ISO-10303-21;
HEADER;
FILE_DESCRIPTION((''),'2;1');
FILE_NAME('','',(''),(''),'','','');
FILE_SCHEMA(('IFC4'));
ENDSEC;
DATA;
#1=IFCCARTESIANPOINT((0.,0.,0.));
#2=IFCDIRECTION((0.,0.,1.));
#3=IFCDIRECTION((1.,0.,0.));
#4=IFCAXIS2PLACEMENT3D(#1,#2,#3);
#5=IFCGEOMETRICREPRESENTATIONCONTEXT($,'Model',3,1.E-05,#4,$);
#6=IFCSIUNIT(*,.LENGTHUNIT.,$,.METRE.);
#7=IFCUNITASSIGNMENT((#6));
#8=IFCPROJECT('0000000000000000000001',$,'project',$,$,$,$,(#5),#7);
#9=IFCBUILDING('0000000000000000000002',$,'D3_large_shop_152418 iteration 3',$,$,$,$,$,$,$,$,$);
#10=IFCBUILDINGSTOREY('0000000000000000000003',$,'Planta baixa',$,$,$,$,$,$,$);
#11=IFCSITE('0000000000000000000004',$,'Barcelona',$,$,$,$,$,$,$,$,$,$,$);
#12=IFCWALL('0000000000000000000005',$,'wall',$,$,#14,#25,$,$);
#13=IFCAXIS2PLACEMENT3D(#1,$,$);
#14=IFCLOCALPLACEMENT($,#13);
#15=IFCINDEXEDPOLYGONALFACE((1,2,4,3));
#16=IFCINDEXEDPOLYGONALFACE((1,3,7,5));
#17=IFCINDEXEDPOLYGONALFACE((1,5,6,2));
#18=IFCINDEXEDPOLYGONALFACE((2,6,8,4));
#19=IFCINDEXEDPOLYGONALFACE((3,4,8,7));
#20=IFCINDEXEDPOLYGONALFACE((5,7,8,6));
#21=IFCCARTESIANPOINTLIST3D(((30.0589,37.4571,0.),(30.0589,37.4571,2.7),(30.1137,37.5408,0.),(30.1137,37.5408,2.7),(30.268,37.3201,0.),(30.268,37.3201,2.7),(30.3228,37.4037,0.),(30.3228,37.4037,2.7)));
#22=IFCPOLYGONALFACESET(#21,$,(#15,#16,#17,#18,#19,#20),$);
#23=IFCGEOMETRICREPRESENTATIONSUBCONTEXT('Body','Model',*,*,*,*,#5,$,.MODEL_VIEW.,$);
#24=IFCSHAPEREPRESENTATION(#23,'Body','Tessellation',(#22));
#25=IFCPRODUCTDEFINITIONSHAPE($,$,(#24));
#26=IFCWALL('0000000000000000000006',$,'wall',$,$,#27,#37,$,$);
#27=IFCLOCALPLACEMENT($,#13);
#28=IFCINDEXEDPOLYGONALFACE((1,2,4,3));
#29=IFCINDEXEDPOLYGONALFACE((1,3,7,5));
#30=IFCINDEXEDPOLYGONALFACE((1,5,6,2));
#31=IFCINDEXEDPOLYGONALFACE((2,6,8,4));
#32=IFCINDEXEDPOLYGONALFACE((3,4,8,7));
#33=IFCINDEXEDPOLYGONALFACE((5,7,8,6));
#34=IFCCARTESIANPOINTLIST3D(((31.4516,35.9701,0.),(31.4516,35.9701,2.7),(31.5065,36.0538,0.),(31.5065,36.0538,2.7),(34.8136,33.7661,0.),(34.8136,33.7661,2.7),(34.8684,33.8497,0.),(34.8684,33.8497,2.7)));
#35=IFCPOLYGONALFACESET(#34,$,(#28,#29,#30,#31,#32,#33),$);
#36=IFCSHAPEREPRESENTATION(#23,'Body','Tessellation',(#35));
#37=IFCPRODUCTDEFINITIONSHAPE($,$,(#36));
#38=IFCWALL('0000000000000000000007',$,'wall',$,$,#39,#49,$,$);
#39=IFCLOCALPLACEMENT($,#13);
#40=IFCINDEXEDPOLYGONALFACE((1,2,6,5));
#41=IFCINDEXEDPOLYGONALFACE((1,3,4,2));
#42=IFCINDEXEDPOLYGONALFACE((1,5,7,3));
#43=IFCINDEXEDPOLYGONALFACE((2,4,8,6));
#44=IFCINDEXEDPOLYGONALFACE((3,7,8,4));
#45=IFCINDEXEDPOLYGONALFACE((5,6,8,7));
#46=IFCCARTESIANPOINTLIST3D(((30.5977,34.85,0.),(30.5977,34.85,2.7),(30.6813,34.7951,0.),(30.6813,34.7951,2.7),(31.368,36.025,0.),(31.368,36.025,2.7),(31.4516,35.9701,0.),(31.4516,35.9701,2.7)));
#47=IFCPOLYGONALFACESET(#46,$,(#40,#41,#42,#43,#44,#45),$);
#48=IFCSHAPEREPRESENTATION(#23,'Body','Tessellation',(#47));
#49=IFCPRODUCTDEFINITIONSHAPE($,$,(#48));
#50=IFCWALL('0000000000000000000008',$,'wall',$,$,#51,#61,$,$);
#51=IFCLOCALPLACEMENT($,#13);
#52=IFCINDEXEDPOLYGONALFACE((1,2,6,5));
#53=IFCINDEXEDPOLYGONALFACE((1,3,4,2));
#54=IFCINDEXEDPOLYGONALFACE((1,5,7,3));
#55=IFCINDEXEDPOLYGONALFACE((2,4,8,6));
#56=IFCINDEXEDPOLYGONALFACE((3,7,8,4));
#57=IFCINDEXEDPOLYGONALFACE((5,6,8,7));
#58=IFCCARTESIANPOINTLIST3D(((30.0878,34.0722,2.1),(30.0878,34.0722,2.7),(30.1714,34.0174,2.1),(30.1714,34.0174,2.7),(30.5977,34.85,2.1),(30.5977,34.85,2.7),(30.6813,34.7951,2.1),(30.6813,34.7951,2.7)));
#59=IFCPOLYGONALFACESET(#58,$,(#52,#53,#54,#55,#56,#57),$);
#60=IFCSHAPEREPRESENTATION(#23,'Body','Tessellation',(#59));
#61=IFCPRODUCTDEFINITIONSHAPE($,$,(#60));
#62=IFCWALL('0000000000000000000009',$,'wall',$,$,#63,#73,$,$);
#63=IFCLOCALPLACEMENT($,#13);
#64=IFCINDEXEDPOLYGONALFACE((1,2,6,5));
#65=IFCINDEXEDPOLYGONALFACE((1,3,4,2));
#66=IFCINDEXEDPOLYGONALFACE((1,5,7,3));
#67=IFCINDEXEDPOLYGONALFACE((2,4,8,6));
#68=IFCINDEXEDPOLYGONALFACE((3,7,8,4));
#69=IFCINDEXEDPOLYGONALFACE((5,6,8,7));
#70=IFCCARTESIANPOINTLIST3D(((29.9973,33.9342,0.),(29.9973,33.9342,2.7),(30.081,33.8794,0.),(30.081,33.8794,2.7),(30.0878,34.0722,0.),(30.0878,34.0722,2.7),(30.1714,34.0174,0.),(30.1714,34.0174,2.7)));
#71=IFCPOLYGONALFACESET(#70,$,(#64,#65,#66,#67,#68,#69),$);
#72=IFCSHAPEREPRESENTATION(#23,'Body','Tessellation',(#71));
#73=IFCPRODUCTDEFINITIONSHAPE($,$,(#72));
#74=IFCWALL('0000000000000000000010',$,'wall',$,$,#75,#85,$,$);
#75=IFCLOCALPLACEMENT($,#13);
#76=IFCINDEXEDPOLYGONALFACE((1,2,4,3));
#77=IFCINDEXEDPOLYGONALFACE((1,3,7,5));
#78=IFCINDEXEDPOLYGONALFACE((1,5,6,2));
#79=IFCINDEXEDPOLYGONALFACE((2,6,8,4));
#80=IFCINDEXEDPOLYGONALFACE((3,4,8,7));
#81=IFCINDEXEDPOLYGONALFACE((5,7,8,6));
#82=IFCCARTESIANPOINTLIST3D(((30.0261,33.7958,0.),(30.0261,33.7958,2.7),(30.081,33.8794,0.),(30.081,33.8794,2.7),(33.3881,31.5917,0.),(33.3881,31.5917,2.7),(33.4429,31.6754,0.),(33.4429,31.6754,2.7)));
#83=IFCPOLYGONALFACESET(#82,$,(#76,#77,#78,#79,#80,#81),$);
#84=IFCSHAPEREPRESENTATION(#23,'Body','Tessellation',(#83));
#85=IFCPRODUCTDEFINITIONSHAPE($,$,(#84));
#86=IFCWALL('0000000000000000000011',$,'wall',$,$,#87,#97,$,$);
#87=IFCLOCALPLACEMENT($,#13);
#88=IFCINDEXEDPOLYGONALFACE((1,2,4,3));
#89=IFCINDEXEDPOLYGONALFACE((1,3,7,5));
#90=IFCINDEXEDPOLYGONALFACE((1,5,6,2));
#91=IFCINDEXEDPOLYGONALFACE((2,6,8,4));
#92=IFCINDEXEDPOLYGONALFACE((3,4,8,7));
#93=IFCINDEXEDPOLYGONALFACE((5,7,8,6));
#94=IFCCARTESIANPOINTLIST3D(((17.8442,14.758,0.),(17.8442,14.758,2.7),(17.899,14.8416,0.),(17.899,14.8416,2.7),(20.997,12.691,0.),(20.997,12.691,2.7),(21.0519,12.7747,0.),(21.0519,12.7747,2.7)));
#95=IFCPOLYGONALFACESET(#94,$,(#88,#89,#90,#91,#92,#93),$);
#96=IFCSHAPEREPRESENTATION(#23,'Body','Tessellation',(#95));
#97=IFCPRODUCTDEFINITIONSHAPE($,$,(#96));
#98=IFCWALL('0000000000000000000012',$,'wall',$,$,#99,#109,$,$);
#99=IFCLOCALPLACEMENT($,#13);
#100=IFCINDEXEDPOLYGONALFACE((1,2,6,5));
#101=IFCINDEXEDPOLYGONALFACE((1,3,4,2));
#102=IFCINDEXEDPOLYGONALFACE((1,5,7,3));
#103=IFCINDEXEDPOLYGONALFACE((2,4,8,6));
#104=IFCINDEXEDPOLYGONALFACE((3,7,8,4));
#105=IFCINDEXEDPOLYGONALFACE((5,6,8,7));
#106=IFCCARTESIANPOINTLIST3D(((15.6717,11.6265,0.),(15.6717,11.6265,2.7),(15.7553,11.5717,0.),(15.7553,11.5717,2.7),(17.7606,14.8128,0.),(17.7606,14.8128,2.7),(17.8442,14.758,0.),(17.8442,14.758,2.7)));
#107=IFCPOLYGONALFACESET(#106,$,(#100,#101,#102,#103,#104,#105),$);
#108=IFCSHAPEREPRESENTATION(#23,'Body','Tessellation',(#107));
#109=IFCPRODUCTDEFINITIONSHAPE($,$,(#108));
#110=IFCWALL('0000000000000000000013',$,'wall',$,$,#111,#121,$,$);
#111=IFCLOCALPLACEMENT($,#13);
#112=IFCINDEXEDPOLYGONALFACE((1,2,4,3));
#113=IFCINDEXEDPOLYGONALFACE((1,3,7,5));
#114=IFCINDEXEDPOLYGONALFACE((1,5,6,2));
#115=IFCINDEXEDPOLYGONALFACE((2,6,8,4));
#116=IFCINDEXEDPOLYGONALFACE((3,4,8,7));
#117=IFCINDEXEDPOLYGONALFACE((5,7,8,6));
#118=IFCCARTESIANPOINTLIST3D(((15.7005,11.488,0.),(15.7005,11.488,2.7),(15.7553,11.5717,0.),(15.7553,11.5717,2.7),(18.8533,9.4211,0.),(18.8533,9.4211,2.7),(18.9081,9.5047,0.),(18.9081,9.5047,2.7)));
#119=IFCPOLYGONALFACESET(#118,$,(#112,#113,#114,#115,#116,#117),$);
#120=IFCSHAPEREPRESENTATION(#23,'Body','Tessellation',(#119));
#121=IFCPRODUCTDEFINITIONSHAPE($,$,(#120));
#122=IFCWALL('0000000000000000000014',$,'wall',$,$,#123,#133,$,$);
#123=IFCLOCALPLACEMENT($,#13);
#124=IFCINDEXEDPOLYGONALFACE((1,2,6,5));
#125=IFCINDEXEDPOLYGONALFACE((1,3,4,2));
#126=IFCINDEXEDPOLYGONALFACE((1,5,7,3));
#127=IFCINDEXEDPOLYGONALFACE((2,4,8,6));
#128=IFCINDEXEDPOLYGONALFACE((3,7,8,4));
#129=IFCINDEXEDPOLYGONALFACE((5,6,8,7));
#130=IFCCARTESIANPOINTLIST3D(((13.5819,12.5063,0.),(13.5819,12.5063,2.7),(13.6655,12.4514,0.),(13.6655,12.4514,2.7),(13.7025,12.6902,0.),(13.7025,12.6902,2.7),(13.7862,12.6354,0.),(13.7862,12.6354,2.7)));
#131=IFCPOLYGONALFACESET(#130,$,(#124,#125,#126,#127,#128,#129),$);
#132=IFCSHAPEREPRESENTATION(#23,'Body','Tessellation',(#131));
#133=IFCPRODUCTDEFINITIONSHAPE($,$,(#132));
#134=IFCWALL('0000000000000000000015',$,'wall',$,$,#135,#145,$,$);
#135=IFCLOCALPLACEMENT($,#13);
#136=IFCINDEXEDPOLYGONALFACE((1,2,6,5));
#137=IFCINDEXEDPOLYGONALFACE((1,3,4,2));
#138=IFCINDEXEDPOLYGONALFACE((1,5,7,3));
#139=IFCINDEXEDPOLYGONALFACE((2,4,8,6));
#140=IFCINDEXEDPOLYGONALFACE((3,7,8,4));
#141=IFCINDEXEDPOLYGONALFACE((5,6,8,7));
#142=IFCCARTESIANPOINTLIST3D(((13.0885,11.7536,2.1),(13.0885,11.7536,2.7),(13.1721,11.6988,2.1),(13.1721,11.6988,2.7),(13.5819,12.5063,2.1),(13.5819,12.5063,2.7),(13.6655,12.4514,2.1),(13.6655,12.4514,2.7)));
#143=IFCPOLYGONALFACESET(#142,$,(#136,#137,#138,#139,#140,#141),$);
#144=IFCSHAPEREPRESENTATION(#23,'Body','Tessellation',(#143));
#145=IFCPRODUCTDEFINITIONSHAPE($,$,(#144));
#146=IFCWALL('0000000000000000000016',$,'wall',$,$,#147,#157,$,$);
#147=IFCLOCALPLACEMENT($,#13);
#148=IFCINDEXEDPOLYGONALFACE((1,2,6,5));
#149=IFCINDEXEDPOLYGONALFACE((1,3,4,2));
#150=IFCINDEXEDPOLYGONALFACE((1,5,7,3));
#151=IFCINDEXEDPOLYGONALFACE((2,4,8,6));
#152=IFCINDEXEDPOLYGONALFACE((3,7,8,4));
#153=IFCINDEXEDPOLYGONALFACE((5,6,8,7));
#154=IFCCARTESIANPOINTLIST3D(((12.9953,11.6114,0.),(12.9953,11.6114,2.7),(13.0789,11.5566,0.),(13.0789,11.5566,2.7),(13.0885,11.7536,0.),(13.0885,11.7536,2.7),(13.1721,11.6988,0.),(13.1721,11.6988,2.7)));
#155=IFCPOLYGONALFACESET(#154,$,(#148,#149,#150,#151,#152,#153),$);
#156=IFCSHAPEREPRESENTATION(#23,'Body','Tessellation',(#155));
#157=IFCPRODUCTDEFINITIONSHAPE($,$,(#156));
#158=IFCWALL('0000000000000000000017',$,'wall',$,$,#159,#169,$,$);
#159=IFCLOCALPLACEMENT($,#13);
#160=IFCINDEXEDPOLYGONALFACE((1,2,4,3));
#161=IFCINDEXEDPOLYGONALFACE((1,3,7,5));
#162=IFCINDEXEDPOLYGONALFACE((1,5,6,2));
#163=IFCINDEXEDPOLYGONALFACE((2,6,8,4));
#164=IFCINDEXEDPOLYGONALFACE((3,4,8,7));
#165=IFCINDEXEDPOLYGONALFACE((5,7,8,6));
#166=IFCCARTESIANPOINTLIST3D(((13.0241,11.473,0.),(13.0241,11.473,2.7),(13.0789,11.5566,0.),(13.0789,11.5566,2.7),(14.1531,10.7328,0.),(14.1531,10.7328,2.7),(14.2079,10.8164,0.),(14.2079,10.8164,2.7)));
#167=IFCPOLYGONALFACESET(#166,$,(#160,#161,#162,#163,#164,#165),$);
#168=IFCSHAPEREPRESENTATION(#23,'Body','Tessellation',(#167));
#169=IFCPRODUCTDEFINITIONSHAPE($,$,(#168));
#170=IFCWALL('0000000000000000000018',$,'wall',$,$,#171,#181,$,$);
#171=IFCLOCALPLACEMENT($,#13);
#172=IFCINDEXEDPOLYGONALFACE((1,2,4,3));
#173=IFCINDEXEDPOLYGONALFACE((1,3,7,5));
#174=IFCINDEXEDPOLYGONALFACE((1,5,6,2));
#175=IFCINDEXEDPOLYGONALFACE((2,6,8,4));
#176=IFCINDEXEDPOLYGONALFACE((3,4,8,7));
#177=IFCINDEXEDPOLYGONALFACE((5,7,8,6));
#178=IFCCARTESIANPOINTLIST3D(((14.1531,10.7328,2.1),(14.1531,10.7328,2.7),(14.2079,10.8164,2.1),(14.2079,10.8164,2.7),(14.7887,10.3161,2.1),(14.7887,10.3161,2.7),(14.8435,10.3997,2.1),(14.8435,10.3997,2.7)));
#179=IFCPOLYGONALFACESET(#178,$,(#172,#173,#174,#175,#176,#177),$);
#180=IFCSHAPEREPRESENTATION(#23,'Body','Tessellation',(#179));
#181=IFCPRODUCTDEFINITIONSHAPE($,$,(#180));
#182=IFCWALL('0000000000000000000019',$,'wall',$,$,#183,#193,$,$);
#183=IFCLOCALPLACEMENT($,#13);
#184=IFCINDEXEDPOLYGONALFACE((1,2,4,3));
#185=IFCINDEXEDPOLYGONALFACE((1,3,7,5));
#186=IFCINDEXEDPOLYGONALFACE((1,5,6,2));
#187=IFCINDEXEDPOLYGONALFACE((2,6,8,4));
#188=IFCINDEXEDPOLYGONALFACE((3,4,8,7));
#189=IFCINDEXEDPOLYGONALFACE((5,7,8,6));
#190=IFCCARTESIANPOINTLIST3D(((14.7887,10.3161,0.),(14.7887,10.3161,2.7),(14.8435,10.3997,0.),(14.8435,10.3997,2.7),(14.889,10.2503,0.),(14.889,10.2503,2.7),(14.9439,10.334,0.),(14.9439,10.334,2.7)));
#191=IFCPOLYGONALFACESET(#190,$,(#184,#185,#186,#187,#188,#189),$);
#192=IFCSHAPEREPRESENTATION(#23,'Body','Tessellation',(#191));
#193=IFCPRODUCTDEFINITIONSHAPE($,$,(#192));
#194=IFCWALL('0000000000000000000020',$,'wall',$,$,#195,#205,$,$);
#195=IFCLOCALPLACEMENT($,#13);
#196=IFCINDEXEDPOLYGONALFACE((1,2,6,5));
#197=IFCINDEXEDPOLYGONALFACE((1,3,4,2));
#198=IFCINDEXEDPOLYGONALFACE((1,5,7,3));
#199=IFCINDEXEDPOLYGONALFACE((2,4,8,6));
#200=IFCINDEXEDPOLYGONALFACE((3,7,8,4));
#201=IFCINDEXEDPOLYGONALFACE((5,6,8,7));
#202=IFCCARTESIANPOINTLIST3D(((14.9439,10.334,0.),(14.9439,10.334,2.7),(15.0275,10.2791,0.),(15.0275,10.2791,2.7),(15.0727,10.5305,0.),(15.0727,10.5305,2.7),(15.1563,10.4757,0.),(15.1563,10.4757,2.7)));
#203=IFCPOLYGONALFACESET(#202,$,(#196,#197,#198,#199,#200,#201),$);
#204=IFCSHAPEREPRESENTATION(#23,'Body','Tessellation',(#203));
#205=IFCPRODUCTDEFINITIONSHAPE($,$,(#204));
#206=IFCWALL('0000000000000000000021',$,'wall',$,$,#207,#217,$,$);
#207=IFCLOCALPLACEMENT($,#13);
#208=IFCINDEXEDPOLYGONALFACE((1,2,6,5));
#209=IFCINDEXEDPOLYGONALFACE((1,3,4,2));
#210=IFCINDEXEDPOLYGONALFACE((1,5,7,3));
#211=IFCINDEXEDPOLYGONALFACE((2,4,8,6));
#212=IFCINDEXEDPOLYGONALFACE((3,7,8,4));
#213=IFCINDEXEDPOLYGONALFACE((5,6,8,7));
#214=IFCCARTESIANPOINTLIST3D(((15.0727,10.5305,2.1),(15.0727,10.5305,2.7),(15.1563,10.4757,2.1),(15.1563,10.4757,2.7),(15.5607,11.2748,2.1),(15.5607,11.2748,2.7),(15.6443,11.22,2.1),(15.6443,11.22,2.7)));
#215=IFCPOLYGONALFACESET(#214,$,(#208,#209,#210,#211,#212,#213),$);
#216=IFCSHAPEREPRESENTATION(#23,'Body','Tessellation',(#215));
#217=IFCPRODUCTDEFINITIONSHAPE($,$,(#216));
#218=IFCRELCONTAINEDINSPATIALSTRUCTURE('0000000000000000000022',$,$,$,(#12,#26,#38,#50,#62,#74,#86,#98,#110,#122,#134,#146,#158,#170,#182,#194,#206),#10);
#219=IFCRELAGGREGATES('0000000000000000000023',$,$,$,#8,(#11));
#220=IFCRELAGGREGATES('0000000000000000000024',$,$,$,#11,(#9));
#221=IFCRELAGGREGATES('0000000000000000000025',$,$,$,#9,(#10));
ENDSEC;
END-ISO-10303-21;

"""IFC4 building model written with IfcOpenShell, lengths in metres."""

from ifc_helpers import new_model, si_unit, frame, origin, origin_with_axes, place, context, subcontext, project, spatial, polyline, outline, extrude, element, save


model = new_model("IFC4")

# Units and contexts
model_context = context("Model", 3, precision=1e-05, world=origin_with_axes())
body_context = subcontext(model_context, "Body", "Model", "MODEL_VIEW")
ifc_project = project(units=[si_unit("LENGTHUNIT", "METRE")], contexts=[model_context])

# Site, building, storey
site = spatial("IfcSite", under=ifc_project, Name="Barcelona")
building = spatial("IfcBuilding", under=site, Name="D3_large_shop_152418 iteration 3")
storey = spatial("IfcBuildingStorey", under=building, Name="Planta baixa")

# Walls
wall_1_placement = place(None, origin_with_axes())
element("IfcWall", 1, at=wall_1_placement, inside=storey, Name="wall", context=body_context, shape_type="SweptSolid", body=[
    extrude(outline(polyline([(30.1137, 37.5408), (30.3228, 37.4037), (30.268, 37.3201), (30.0589, 37.4571), (30.1137, 37.5408)])), origin(), (0.0, 0.0, 1.0), 2.7),
])
wall_2_placement = place(None, origin_with_axes())
element("IfcWall", 2, at=wall_2_placement, inside=storey, Name="wall", context=body_context, shape_type="SweptSolid", body=[
    extrude(outline(polyline([(34.8136, 33.7661), (31.4516, 35.9701), (31.5065, 36.0538), (34.8684, 33.8497), (34.8136, 33.7661)])), origin(), (0.0, 0.0, 1.0), 2.7),
])
wall_3_placement = place(None, origin_with_axes())
element("IfcWall", 3, at=wall_3_placement, inside=storey, Name="wall", context=body_context, shape_type="SweptSolid", body=[
    extrude(outline(polyline([(31.4516, 35.9701), (30.6813, 34.7951), (30.5977, 34.85), (31.368, 36.025), (31.4516, 35.9701)])), origin(), (0.0, 0.0, 1.0), 2.7),
])
wall_4_placement = place(None, origin_with_axes())
element("IfcWall", 4, at=wall_4_placement, inside=storey, Name="wall", context=body_context, shape_type="SweptSolid", body=[
    extrude(outline(polyline([(30.6813, 34.7951), (30.1714, 34.0174), (30.0878, 34.0722), (30.5977, 34.85), (30.6813, 34.7951)])), frame((0.0, 0.0, 2.1)), (0.0, 0.0, 1.0), 0.6),
])
wall_5_placement = place(None, origin_with_axes())
element("IfcWall", 5, at=wall_5_placement, inside=storey, Name="wall", context=body_context, shape_type="SweptSolid", body=[
    extrude(outline(polyline([(30.1714, 34.0174), (30.081, 33.8794), (29.9973, 33.9342), (30.0878, 34.0722), (30.1714, 34.0174)])), origin(), (0.0, 0.0, 1.0), 2.7),
])
wall_6_placement = place(None, origin_with_axes())
element("IfcWall", 6, at=wall_6_placement, inside=storey, Name="wall", context=body_context, shape_type="SweptSolid", body=[
    extrude(outline(polyline([(30.081, 33.8794), (33.4429, 31.6754), (33.3881, 31.5917), (30.0261, 33.7958), (30.081, 33.8794)])), origin(), (0.0, 0.0, 1.0), 2.7),
])
wall_7_placement = place(None, origin_with_axes())
element("IfcWall", 7, at=wall_7_placement, inside=storey, Name="wall", context=body_context, shape_type="SweptSolid", body=[
    extrude(outline(polyline([(20.997, 12.691), (17.8442, 14.758), (17.899, 14.8416), (21.0519, 12.7747), (20.997, 12.691)])), origin(), (0.0, 0.0, 1.0), 2.7),
])
wall_8_placement = place(None, origin_with_axes())
element("IfcWall", 8, at=wall_8_placement, inside=storey, Name="wall", context=body_context, shape_type="SweptSolid", body=[
    extrude(outline(polyline([(17.8442, 14.758), (15.7553, 11.5717), (15.6717, 11.6265), (17.7606, 14.8128), (17.8442, 14.758)])), origin(), (0.0, 0.0, 1.0), 2.7),
])
wall_9_placement = place(None, origin_with_axes())
element("IfcWall", 9, at=wall_9_placement, inside=storey, Name="wall", context=body_context, shape_type="SweptSolid", body=[
    extrude(outline(polyline([(15.7553, 11.5717), (18.9081, 9.5047), (18.8533, 9.4211), (15.7005, 11.488), (15.7553, 11.5717)])), origin(), (0.0, 0.0, 1.0), 2.7),
])
wall_10_placement = place(None, origin_with_axes())
element("IfcWall", 10, at=wall_10_placement, inside=storey, Name="wall", context=body_context, shape_type="SweptSolid", body=[
    extrude(outline(polyline([(13.7862, 12.6354), (13.6655, 12.4514), (13.5819, 12.5063), (13.7025, 12.6902), (13.7862, 12.6354)])), origin(), (0.0, 0.0, 1.0), 2.7),
])
wall_11_placement = place(None, origin_with_axes())
element("IfcWall", 11, at=wall_11_placement, inside=storey, Name="wall", context=body_context, shape_type="SweptSolid", body=[
    extrude(outline(polyline([(13.6655, 12.4514), (13.1721, 11.6988), (13.0885, 11.7536), (13.5819, 12.5063), (13.6655, 12.4514)])), frame((0.0, 0.0, 2.1)), (0.0, 0.0, 1.0), 0.6),
])
wall_12_placement = place(None, origin_with_axes())
element("IfcWall", 12, at=wall_12_placement, inside=storey, Name="wall", context=body_context, shape_type="SweptSolid", body=[
    extrude(outline(polyline([(13.1721, 11.6988), (13.0789, 11.5566), (12.9953, 11.6114), (13.0885, 11.7536), (13.1721, 11.6988)])), origin(), (0.0, 0.0, 1.0), 2.7),
])
wall_13_placement = place(None, origin_with_axes())
element("IfcWall", 13, at=wall_13_placement, inside=storey, Name="wall", context=body_context, shape_type="SweptSolid", body=[
    extrude(outline(polyline([(13.0789, 11.5566), (14.2079, 10.8164), (14.1531, 10.7328), (13.0241, 11.473), (13.0789, 11.5566)])), origin(), (0.0, 0.0, 1.0), 2.7),
])
wall_14_placement = place(None, origin_with_axes())
element("IfcWall", 14, at=wall_14_placement, inside=storey, Name="wall", context=body_context, shape_type="SweptSolid", body=[
    extrude(outline(polyline([(14.2079, 10.8164), (14.8435, 10.3997), (14.7887, 10.3161), (14.1531, 10.7328), (14.2079, 10.8164)])), frame((0.0, 0.0, 2.1)), (0.0, 0.0, 1.0), 0.6),
])
wall_15_placement = place(None, origin_with_axes())
element("IfcWall", 15, at=wall_15_placement, inside=storey, Name="wall", context=body_context, shape_type="SweptSolid", body=[
    extrude(outline(polyline([(14.8435, 10.3997), (14.9439, 10.334), (14.889, 10.2503), (14.7887, 10.3161), (14.8435, 10.3997)])), origin(), (0.0, 0.0, 1.0), 2.7),
])
wall_16_placement = place(None, origin_with_axes())
element("IfcWall", 16, at=wall_16_placement, inside=storey, Name="wall", context=body_context, shape_type="SweptSolid", body=[
    extrude(outline(polyline([(14.9439, 10.334), (15.0727, 10.5305), (15.1563, 10.4757), (15.0275, 10.2791), (14.9439, 10.334)])), origin(), (0.0, 0.0, 1.0), 2.7),
])
wall_17_placement = place(None, origin_with_axes())
element("IfcWall", 17, at=wall_17_placement, inside=storey, Name="wall", context=body_context, shape_type="SweptSolid", body=[
    extrude(outline(polyline([(15.0727, 10.5305), (15.5607, 11.2748), (15.6443, 11.22), (15.1563, 10.4757), (15.0727, 10.5305)])), frame((0.0, 0.0, 2.1)), (0.0, 0.0, 1.0), 0.6),
])

save(model, "model.ifc")
